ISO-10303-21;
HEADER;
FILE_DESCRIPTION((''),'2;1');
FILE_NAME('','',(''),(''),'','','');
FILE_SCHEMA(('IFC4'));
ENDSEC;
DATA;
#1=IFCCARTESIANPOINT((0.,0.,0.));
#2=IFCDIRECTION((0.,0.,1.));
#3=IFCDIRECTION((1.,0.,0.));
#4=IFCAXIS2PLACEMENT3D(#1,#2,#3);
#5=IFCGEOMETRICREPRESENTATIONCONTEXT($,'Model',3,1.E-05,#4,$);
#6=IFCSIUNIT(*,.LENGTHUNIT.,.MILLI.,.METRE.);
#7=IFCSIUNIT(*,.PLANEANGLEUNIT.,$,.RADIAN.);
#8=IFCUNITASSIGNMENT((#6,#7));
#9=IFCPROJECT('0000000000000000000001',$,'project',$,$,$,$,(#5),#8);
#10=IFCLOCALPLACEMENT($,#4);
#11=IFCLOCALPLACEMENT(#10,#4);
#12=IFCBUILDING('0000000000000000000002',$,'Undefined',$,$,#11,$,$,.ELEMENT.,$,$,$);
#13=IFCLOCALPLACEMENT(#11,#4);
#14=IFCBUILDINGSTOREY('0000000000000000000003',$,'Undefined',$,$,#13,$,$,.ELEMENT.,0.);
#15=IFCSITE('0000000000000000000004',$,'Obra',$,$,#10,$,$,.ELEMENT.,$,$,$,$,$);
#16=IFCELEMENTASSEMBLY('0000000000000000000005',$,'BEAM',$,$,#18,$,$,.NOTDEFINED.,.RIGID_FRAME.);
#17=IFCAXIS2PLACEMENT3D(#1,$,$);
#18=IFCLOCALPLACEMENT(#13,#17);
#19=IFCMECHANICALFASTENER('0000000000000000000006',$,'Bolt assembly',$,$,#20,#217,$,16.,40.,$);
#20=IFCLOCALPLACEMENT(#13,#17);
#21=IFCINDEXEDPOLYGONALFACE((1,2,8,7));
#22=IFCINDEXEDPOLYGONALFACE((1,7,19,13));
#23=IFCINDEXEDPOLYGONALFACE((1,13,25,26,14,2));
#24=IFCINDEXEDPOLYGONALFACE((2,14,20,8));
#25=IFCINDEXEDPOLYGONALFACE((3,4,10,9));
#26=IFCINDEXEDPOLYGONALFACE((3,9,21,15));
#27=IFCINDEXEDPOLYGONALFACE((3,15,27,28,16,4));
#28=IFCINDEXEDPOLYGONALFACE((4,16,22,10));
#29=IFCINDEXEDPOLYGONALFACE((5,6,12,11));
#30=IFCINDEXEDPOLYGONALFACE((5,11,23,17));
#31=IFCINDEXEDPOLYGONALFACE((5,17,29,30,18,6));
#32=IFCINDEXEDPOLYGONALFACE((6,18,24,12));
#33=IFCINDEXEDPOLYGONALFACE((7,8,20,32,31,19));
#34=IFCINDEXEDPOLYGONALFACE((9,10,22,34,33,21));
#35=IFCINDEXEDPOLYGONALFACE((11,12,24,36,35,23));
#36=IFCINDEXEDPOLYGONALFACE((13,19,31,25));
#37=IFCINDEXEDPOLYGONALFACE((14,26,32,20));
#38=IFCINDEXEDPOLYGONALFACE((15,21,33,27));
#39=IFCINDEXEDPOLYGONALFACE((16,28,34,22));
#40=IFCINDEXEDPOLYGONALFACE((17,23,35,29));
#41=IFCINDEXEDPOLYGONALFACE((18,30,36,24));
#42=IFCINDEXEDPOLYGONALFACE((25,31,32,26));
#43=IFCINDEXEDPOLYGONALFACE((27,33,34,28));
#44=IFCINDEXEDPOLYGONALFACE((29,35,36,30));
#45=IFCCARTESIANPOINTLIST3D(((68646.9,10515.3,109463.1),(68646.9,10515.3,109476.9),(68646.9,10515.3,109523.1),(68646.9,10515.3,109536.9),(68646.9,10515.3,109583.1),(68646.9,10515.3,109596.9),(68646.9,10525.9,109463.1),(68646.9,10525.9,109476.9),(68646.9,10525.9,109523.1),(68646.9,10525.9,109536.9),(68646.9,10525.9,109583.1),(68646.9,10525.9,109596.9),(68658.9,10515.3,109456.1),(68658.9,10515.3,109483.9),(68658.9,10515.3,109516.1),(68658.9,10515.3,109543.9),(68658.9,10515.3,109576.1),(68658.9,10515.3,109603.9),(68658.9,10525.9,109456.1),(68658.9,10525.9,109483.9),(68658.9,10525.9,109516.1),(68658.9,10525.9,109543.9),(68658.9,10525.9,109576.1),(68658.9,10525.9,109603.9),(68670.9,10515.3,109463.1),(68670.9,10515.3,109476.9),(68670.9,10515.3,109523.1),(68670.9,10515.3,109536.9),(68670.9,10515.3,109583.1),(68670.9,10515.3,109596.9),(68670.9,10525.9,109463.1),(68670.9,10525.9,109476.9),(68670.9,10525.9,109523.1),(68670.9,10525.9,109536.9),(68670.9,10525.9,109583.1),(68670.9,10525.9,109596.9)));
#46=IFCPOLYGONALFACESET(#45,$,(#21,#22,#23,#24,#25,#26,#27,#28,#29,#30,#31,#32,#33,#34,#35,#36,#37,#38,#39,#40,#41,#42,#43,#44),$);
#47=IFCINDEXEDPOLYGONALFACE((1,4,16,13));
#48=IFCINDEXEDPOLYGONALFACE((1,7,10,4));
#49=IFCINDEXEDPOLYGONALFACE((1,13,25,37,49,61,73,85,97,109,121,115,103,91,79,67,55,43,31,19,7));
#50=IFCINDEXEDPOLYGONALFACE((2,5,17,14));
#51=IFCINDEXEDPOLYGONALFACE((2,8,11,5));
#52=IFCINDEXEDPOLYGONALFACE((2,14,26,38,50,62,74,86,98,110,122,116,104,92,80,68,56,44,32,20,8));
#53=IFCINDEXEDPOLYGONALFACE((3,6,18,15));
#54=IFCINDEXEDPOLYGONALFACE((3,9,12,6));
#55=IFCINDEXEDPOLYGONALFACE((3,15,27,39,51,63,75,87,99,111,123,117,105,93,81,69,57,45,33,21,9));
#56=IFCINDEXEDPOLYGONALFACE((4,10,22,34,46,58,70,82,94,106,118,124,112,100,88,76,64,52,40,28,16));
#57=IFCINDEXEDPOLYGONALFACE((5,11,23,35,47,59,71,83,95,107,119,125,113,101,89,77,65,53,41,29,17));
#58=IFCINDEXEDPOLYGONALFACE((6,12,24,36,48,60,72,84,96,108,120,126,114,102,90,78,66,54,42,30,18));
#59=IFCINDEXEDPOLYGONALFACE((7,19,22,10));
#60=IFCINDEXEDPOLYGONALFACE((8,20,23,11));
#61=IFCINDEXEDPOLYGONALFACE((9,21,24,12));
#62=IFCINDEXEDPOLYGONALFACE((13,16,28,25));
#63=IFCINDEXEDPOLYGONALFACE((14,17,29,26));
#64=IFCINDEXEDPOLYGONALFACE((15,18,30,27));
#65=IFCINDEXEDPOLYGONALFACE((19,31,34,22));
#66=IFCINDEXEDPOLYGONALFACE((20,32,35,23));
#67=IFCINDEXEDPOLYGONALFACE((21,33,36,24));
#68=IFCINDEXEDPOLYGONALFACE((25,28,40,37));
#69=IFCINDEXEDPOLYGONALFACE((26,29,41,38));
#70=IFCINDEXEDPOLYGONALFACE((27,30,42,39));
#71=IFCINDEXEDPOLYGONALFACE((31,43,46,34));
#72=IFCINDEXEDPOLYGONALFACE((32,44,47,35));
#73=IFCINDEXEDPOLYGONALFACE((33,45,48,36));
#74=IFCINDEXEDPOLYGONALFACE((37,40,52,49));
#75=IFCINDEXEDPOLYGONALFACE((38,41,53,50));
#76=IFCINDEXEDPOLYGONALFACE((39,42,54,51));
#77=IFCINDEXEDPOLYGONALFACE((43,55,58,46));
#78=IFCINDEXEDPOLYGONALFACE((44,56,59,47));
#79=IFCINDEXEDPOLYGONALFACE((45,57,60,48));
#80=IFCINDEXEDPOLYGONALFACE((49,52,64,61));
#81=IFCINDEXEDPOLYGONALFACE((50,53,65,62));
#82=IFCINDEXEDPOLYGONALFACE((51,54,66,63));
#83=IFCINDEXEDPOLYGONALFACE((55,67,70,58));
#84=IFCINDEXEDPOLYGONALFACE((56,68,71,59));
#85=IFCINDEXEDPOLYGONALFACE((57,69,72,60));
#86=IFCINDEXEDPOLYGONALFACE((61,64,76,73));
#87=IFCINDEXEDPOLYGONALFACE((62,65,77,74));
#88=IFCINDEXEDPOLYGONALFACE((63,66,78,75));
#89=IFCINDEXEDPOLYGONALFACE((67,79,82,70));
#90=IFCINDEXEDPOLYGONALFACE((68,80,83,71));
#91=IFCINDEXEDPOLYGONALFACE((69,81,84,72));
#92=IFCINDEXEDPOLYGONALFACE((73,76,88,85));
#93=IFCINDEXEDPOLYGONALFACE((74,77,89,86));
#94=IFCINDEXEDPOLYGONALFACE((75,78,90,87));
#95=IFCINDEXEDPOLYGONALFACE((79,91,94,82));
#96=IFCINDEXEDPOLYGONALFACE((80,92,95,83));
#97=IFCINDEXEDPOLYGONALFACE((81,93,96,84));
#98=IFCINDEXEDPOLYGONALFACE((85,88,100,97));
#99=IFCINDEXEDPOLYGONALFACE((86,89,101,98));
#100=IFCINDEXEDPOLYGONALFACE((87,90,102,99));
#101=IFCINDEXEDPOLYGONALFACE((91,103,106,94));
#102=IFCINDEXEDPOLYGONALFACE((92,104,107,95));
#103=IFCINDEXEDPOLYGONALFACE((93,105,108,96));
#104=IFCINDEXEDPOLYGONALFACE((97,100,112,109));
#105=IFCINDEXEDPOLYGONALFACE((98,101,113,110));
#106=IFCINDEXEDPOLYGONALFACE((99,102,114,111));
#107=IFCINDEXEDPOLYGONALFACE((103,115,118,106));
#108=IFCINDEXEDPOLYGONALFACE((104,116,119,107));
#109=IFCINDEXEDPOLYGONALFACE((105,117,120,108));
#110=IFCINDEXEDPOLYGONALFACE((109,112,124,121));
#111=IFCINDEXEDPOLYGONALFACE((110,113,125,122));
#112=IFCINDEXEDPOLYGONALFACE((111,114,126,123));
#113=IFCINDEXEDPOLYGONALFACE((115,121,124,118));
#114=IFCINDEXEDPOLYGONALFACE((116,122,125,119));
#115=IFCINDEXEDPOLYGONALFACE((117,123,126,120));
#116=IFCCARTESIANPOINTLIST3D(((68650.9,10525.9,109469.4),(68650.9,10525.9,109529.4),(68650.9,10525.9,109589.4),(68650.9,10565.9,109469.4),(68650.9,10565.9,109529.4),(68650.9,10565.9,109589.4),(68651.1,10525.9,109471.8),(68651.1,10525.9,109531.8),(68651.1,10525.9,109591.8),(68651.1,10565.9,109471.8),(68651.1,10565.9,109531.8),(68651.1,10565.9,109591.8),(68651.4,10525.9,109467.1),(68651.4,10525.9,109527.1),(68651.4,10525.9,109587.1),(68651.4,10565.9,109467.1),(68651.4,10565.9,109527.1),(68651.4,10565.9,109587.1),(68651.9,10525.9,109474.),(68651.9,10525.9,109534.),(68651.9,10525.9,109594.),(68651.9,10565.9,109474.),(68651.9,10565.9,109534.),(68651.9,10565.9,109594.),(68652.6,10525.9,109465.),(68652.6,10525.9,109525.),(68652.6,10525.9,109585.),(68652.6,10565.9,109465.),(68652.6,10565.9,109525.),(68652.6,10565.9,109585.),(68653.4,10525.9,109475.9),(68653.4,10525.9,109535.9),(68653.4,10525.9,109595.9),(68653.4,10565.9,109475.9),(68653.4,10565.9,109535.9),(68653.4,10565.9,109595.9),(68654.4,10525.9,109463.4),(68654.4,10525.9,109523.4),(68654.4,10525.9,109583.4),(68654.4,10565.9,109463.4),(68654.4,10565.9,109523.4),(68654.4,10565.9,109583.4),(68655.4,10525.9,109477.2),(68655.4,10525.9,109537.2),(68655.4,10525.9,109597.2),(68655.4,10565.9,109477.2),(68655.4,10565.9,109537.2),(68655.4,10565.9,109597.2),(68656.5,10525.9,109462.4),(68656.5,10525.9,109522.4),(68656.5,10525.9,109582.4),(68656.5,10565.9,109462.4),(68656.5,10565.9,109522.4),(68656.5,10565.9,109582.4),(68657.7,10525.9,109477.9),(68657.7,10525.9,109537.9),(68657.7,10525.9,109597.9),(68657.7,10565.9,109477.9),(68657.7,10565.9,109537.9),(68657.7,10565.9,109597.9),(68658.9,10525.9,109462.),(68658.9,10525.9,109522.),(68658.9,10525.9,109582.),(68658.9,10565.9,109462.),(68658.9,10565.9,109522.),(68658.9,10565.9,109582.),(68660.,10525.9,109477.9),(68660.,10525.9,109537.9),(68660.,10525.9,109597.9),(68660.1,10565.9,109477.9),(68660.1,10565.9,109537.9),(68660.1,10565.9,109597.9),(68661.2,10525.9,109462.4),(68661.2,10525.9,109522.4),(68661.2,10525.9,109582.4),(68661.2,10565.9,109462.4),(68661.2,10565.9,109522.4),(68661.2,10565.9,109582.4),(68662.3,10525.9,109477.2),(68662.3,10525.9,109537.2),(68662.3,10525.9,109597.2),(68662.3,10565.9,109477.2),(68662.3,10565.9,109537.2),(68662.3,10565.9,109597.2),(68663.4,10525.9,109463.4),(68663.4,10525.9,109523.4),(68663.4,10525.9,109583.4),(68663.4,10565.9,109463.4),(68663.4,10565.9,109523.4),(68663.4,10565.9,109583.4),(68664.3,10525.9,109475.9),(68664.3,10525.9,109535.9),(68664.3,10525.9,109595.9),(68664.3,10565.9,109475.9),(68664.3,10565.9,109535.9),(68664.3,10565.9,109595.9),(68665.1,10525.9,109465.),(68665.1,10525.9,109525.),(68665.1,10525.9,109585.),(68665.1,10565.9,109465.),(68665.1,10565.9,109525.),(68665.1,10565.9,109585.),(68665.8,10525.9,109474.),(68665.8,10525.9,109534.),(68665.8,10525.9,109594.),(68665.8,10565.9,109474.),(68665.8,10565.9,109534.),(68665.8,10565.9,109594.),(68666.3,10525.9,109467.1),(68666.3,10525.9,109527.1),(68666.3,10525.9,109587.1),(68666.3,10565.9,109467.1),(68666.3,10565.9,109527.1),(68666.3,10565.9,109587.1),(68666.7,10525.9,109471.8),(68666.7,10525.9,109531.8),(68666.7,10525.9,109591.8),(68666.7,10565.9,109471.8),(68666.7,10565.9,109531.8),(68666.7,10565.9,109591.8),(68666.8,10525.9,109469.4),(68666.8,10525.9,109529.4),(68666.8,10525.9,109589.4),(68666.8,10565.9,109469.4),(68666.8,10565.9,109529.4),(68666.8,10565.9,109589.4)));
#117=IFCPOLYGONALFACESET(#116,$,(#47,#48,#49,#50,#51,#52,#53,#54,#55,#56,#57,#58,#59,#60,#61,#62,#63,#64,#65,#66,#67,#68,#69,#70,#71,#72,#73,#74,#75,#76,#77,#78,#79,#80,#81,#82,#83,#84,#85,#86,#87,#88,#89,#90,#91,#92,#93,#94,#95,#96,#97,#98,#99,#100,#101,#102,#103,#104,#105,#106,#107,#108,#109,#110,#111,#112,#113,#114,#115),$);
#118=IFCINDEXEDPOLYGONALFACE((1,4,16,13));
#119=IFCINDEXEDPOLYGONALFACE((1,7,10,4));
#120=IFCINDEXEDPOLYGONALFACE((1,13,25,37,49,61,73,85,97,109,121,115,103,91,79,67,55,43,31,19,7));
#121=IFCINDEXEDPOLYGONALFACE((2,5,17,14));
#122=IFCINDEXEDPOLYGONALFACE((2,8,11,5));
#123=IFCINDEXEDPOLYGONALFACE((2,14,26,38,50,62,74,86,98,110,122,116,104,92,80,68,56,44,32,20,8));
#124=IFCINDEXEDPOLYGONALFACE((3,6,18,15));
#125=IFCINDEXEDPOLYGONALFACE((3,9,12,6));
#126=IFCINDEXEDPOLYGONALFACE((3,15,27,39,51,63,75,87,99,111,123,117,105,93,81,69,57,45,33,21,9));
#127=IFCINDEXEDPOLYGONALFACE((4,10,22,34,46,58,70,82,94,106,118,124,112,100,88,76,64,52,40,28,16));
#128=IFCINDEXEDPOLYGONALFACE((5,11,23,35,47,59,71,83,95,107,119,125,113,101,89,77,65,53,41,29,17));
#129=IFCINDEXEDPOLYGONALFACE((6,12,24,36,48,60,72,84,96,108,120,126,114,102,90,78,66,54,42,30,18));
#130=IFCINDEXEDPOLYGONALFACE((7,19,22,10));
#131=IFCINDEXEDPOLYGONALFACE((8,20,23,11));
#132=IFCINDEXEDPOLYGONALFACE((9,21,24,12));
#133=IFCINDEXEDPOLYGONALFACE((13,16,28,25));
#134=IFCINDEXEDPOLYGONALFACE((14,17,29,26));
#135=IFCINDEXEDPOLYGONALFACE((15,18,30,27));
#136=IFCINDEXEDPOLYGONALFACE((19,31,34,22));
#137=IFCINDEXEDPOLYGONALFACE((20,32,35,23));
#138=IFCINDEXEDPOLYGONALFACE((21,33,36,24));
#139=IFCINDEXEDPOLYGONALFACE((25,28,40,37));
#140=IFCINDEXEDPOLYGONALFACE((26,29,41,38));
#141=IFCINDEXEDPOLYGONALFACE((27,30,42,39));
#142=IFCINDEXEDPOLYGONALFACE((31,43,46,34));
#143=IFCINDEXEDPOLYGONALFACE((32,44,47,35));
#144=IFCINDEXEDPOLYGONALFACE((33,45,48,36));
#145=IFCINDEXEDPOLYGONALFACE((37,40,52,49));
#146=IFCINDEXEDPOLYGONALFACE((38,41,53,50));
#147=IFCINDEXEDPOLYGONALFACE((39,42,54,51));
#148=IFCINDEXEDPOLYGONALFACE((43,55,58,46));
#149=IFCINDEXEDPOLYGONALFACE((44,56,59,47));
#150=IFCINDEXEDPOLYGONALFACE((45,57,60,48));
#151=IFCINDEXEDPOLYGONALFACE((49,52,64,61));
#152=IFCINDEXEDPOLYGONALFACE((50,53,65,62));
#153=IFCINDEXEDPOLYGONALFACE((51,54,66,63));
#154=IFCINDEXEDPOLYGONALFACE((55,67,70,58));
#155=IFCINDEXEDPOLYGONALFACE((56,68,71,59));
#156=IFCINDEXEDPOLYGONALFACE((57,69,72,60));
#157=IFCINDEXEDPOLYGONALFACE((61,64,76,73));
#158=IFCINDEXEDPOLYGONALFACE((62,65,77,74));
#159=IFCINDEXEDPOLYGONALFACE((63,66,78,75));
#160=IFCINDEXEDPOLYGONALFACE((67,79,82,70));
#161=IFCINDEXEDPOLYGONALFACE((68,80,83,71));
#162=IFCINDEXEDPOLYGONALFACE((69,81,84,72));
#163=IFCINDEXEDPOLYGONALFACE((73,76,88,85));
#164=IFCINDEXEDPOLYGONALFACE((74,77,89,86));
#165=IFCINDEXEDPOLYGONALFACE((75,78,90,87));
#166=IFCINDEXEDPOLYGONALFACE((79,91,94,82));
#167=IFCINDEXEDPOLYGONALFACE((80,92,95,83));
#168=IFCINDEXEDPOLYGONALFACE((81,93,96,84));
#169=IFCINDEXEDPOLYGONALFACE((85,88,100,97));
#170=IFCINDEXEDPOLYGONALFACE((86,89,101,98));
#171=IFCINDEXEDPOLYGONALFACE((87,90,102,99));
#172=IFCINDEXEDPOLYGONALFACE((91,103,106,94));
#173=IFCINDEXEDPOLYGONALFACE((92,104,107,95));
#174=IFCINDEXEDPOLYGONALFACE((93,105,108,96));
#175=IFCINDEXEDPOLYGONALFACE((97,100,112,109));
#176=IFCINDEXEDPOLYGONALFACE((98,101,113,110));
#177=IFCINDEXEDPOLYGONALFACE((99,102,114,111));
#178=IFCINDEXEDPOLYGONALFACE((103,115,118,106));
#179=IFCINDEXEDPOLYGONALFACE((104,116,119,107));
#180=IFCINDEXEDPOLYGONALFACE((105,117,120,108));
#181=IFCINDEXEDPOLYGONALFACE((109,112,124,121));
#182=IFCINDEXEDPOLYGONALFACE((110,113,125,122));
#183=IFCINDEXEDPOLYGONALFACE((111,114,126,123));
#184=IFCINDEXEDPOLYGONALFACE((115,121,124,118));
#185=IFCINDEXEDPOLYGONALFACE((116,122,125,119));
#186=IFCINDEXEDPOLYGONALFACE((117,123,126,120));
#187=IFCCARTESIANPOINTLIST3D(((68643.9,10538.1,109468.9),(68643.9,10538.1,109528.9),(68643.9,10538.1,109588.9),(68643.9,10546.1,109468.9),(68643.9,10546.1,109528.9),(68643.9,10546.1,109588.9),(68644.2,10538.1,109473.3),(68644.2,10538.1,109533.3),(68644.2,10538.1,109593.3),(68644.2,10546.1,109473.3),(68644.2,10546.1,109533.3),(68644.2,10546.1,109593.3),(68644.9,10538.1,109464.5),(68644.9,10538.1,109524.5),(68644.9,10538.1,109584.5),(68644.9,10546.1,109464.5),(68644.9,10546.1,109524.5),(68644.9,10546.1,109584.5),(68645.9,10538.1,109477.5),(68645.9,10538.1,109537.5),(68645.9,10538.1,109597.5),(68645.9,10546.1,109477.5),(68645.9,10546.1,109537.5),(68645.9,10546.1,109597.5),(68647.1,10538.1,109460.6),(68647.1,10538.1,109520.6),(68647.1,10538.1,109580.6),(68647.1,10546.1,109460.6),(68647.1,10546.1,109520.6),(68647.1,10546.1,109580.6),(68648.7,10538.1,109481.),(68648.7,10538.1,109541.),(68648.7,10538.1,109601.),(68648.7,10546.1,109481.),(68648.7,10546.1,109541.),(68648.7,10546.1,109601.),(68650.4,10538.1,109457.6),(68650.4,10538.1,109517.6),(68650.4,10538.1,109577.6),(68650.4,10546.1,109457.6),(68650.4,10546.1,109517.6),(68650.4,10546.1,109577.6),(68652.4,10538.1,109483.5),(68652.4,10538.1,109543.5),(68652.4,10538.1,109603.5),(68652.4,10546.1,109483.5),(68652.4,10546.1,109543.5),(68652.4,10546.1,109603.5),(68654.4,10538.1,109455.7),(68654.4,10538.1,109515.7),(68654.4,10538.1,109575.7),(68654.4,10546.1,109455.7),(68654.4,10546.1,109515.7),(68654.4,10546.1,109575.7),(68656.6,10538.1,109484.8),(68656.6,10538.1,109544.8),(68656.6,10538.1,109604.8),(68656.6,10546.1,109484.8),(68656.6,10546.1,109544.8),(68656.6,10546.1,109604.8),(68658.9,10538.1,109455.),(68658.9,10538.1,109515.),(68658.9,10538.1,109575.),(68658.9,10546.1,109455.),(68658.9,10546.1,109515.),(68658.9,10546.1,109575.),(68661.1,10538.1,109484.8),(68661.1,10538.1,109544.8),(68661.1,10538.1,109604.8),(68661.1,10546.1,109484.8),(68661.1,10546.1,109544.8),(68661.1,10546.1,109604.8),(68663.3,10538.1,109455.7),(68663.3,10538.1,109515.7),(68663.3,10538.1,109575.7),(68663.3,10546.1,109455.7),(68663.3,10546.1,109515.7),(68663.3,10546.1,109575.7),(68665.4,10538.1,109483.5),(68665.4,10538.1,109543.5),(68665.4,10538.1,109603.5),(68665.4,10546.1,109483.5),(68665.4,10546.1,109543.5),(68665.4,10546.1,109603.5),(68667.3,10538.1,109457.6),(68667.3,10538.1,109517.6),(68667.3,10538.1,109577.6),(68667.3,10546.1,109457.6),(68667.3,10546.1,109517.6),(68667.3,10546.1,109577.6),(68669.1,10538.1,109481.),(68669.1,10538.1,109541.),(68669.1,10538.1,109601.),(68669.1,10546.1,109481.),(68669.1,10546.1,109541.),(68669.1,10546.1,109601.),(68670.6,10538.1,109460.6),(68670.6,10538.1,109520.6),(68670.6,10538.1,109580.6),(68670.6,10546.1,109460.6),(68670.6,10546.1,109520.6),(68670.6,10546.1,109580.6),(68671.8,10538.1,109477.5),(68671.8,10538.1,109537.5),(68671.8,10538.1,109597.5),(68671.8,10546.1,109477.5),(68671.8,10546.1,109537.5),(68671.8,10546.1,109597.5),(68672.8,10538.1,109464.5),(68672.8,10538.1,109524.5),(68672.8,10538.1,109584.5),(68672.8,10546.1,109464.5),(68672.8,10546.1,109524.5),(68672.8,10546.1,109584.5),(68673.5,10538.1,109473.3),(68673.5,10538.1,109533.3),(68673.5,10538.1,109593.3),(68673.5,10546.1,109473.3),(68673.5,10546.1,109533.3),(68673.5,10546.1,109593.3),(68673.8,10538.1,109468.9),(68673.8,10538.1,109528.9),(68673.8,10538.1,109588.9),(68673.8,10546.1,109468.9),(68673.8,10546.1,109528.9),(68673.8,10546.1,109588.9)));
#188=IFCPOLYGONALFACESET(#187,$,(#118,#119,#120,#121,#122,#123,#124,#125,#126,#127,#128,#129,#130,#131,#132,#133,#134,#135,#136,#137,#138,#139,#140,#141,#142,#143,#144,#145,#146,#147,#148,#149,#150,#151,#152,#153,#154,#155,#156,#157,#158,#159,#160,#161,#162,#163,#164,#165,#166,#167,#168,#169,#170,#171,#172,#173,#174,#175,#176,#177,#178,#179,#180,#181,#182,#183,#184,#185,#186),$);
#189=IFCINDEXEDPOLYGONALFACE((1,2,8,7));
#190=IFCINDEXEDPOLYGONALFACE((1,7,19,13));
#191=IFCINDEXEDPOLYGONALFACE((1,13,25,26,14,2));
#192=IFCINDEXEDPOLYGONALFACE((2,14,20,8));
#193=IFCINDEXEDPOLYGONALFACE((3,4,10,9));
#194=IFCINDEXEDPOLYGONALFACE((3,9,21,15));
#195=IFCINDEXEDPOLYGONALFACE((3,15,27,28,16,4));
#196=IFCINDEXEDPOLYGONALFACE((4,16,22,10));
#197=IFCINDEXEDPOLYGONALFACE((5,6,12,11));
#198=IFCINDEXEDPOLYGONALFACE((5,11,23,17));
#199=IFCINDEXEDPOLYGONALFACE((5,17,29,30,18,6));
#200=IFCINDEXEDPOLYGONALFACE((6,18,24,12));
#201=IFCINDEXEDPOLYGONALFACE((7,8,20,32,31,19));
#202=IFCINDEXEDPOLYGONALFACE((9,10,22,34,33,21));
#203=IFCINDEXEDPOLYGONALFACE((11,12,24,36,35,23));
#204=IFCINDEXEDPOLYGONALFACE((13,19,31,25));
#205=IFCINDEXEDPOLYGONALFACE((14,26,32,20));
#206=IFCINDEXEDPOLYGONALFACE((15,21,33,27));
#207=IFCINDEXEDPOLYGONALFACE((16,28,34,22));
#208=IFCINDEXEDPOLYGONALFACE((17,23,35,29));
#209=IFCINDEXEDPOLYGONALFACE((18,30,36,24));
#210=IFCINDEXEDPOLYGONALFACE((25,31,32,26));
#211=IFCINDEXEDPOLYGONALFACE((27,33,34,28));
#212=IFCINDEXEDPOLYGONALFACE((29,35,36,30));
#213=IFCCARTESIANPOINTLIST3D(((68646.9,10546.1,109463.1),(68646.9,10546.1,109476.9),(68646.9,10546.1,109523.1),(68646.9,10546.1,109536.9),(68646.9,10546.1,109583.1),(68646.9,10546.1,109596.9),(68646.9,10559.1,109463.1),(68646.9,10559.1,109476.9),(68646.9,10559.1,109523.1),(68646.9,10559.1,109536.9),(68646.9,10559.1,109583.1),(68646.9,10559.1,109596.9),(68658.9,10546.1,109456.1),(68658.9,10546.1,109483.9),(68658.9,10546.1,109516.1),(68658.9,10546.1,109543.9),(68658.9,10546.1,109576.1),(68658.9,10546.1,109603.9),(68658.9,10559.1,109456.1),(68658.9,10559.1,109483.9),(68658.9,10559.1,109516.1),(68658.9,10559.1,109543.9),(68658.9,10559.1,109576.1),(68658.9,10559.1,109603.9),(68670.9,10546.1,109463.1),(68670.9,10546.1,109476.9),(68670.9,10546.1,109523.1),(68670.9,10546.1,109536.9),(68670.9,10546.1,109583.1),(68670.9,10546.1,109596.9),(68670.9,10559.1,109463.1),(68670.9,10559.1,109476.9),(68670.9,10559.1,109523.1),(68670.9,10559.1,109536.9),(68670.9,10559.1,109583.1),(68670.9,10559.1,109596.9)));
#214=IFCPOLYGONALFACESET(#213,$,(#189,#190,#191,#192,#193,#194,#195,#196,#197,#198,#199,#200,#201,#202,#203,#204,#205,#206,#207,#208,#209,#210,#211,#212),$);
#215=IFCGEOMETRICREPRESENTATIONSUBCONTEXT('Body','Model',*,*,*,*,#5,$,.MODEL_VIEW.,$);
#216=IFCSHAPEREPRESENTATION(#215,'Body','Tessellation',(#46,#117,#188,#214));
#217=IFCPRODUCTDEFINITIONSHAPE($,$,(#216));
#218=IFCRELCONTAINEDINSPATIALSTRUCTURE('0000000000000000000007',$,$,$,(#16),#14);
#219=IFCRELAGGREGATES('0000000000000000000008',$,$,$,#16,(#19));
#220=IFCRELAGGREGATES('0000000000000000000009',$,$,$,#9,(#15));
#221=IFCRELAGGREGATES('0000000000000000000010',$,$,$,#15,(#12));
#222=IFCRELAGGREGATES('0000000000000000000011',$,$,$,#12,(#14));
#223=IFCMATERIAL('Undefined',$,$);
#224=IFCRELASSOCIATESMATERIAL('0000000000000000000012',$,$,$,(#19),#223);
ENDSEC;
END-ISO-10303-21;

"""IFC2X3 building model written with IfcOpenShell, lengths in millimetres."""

from ifc_helpers import new_model, si_unit, frame, origin_with_axes, origin_2d_with_axis, place, context, subcontext, project, spatial, polyline, circle, outline, extrude, source, transform, mapped, material, element, aggregate, save


model = new_model("IFC2X3")

# Units and contexts
model_context = context("Model", 3, precision=1e-05, world=origin_with_axes())
body_context = subcontext(model_context, "Body", "Model", "MODEL_VIEW")
ifc_project = project(units=[si_unit("LENGTHUNIT", "METRE", prefix="MILLI"), si_unit("PLANEANGLEUNIT", "RADIAN")], contexts=[model_context])

# Site, building, storey
site_placement = place(None, origin_with_axes())
site = spatial("IfcSite", under=ifc_project, at=site_placement, Name="Obra", CompositionType="ELEMENT")
building_placement = place(site_placement, origin_with_axes())
building = spatial("IfcBuilding", under=site, at=building_placement, Name="Undefined", CompositionType="ELEMENT")
storey_placement = place(building_placement, origin_with_axes())
storey = spatial("IfcBuildingStorey", under=building, at=storey_placement, Name="Undefined", CompositionType="ELEMENT", Elevation=0.0)

# Element assembly
assembly_1_placement = place(storey_placement, origin_with_axes())
assembly_1 = element("IfcElementAssembly", 1, at=assembly_1_placement, inside=storey, Name="BEAM", AssemblyPlace="NOTDEFINED", PredefinedType="RIGID_FRAME")

# Shared definitions
ifc_material_1 = material(Name="Undefined")

# Mechanical fastener
shared_shape_1 = source(origin_with_axes(), body_context, "Body", "SweptSolid", [
    extrude(outline(polyline([(13.9, 0.0), (6.9, 12.0), (-6.9, 12.0), (-13.9, 0.0), (-6.9, -12.0), (6.9, -12.0), (13.9, 0.0)])), frame((0.0, -19.7, 0.0), z_axis=(0.0, 1.0, 0.0), x_axis=(1.0, 0.0, 0.0)), (0.0, 0.0, 1.0), 10.6),
    extrude(circle(Radius=8.0, at=origin_2d_with_axis()), frame((0.0, -9.1, 0.0), z_axis=(0.0, 1.0, 0.0), x_axis=(1.0, 0.0, 0.0)), (0.0, 0.0, 1.0), 40.0),
    extrude(circle(Radius=15.0, at=origin_2d_with_axis()), frame((0.0, 3.1, 0.0), z_axis=(0.0, 1.0, 0.0), x_axis=(1.0, 0.0, 0.0)), (0.0, 0.0, 1.0), 8.0),
    extrude(outline(polyline([(13.9, 0.0), (6.9, 12.0), (-6.9, 12.0), (-13.9, 0.0), (-6.9, -12.0), (6.9, -12.0), (13.9, 0.0)])), frame((0.0, 11.1, 0.0), z_axis=(0.0, 1.0, 0.0), x_axis=(1.0, 0.0, 0.0)), (0.0, 0.0, 1.0), 13.0),
])
mechanical_fastener_1_placement = place(assembly_1_placement, frame((68608.9, 10535.0, 109650.0), z_axis=(1.0, -0.000126, 0.0), x_axis=(0.0, 0.0, -1.0)))
mechanical_fastener_1 = element("IfcMechanicalFastener", 2, at=mechanical_fastener_1_placement, material=ifc_material_1, Name="Bolt assembly", NominalDiameter=16.0, NominalLength=40.0, context=body_context, shape_type="MappedRepresentation", body=[
    mapped(shared_shape_1, transform((60.0, 0.0, 50.0))),
    mapped(shared_shape_1, transform((120.0, 0.0, 50.0))),
    mapped(shared_shape_1, transform((180.0, 0.0, 50.0))),
])
aggregate(assembly_1, [mechanical_fastener_1])

save(model, "model.ifc")
